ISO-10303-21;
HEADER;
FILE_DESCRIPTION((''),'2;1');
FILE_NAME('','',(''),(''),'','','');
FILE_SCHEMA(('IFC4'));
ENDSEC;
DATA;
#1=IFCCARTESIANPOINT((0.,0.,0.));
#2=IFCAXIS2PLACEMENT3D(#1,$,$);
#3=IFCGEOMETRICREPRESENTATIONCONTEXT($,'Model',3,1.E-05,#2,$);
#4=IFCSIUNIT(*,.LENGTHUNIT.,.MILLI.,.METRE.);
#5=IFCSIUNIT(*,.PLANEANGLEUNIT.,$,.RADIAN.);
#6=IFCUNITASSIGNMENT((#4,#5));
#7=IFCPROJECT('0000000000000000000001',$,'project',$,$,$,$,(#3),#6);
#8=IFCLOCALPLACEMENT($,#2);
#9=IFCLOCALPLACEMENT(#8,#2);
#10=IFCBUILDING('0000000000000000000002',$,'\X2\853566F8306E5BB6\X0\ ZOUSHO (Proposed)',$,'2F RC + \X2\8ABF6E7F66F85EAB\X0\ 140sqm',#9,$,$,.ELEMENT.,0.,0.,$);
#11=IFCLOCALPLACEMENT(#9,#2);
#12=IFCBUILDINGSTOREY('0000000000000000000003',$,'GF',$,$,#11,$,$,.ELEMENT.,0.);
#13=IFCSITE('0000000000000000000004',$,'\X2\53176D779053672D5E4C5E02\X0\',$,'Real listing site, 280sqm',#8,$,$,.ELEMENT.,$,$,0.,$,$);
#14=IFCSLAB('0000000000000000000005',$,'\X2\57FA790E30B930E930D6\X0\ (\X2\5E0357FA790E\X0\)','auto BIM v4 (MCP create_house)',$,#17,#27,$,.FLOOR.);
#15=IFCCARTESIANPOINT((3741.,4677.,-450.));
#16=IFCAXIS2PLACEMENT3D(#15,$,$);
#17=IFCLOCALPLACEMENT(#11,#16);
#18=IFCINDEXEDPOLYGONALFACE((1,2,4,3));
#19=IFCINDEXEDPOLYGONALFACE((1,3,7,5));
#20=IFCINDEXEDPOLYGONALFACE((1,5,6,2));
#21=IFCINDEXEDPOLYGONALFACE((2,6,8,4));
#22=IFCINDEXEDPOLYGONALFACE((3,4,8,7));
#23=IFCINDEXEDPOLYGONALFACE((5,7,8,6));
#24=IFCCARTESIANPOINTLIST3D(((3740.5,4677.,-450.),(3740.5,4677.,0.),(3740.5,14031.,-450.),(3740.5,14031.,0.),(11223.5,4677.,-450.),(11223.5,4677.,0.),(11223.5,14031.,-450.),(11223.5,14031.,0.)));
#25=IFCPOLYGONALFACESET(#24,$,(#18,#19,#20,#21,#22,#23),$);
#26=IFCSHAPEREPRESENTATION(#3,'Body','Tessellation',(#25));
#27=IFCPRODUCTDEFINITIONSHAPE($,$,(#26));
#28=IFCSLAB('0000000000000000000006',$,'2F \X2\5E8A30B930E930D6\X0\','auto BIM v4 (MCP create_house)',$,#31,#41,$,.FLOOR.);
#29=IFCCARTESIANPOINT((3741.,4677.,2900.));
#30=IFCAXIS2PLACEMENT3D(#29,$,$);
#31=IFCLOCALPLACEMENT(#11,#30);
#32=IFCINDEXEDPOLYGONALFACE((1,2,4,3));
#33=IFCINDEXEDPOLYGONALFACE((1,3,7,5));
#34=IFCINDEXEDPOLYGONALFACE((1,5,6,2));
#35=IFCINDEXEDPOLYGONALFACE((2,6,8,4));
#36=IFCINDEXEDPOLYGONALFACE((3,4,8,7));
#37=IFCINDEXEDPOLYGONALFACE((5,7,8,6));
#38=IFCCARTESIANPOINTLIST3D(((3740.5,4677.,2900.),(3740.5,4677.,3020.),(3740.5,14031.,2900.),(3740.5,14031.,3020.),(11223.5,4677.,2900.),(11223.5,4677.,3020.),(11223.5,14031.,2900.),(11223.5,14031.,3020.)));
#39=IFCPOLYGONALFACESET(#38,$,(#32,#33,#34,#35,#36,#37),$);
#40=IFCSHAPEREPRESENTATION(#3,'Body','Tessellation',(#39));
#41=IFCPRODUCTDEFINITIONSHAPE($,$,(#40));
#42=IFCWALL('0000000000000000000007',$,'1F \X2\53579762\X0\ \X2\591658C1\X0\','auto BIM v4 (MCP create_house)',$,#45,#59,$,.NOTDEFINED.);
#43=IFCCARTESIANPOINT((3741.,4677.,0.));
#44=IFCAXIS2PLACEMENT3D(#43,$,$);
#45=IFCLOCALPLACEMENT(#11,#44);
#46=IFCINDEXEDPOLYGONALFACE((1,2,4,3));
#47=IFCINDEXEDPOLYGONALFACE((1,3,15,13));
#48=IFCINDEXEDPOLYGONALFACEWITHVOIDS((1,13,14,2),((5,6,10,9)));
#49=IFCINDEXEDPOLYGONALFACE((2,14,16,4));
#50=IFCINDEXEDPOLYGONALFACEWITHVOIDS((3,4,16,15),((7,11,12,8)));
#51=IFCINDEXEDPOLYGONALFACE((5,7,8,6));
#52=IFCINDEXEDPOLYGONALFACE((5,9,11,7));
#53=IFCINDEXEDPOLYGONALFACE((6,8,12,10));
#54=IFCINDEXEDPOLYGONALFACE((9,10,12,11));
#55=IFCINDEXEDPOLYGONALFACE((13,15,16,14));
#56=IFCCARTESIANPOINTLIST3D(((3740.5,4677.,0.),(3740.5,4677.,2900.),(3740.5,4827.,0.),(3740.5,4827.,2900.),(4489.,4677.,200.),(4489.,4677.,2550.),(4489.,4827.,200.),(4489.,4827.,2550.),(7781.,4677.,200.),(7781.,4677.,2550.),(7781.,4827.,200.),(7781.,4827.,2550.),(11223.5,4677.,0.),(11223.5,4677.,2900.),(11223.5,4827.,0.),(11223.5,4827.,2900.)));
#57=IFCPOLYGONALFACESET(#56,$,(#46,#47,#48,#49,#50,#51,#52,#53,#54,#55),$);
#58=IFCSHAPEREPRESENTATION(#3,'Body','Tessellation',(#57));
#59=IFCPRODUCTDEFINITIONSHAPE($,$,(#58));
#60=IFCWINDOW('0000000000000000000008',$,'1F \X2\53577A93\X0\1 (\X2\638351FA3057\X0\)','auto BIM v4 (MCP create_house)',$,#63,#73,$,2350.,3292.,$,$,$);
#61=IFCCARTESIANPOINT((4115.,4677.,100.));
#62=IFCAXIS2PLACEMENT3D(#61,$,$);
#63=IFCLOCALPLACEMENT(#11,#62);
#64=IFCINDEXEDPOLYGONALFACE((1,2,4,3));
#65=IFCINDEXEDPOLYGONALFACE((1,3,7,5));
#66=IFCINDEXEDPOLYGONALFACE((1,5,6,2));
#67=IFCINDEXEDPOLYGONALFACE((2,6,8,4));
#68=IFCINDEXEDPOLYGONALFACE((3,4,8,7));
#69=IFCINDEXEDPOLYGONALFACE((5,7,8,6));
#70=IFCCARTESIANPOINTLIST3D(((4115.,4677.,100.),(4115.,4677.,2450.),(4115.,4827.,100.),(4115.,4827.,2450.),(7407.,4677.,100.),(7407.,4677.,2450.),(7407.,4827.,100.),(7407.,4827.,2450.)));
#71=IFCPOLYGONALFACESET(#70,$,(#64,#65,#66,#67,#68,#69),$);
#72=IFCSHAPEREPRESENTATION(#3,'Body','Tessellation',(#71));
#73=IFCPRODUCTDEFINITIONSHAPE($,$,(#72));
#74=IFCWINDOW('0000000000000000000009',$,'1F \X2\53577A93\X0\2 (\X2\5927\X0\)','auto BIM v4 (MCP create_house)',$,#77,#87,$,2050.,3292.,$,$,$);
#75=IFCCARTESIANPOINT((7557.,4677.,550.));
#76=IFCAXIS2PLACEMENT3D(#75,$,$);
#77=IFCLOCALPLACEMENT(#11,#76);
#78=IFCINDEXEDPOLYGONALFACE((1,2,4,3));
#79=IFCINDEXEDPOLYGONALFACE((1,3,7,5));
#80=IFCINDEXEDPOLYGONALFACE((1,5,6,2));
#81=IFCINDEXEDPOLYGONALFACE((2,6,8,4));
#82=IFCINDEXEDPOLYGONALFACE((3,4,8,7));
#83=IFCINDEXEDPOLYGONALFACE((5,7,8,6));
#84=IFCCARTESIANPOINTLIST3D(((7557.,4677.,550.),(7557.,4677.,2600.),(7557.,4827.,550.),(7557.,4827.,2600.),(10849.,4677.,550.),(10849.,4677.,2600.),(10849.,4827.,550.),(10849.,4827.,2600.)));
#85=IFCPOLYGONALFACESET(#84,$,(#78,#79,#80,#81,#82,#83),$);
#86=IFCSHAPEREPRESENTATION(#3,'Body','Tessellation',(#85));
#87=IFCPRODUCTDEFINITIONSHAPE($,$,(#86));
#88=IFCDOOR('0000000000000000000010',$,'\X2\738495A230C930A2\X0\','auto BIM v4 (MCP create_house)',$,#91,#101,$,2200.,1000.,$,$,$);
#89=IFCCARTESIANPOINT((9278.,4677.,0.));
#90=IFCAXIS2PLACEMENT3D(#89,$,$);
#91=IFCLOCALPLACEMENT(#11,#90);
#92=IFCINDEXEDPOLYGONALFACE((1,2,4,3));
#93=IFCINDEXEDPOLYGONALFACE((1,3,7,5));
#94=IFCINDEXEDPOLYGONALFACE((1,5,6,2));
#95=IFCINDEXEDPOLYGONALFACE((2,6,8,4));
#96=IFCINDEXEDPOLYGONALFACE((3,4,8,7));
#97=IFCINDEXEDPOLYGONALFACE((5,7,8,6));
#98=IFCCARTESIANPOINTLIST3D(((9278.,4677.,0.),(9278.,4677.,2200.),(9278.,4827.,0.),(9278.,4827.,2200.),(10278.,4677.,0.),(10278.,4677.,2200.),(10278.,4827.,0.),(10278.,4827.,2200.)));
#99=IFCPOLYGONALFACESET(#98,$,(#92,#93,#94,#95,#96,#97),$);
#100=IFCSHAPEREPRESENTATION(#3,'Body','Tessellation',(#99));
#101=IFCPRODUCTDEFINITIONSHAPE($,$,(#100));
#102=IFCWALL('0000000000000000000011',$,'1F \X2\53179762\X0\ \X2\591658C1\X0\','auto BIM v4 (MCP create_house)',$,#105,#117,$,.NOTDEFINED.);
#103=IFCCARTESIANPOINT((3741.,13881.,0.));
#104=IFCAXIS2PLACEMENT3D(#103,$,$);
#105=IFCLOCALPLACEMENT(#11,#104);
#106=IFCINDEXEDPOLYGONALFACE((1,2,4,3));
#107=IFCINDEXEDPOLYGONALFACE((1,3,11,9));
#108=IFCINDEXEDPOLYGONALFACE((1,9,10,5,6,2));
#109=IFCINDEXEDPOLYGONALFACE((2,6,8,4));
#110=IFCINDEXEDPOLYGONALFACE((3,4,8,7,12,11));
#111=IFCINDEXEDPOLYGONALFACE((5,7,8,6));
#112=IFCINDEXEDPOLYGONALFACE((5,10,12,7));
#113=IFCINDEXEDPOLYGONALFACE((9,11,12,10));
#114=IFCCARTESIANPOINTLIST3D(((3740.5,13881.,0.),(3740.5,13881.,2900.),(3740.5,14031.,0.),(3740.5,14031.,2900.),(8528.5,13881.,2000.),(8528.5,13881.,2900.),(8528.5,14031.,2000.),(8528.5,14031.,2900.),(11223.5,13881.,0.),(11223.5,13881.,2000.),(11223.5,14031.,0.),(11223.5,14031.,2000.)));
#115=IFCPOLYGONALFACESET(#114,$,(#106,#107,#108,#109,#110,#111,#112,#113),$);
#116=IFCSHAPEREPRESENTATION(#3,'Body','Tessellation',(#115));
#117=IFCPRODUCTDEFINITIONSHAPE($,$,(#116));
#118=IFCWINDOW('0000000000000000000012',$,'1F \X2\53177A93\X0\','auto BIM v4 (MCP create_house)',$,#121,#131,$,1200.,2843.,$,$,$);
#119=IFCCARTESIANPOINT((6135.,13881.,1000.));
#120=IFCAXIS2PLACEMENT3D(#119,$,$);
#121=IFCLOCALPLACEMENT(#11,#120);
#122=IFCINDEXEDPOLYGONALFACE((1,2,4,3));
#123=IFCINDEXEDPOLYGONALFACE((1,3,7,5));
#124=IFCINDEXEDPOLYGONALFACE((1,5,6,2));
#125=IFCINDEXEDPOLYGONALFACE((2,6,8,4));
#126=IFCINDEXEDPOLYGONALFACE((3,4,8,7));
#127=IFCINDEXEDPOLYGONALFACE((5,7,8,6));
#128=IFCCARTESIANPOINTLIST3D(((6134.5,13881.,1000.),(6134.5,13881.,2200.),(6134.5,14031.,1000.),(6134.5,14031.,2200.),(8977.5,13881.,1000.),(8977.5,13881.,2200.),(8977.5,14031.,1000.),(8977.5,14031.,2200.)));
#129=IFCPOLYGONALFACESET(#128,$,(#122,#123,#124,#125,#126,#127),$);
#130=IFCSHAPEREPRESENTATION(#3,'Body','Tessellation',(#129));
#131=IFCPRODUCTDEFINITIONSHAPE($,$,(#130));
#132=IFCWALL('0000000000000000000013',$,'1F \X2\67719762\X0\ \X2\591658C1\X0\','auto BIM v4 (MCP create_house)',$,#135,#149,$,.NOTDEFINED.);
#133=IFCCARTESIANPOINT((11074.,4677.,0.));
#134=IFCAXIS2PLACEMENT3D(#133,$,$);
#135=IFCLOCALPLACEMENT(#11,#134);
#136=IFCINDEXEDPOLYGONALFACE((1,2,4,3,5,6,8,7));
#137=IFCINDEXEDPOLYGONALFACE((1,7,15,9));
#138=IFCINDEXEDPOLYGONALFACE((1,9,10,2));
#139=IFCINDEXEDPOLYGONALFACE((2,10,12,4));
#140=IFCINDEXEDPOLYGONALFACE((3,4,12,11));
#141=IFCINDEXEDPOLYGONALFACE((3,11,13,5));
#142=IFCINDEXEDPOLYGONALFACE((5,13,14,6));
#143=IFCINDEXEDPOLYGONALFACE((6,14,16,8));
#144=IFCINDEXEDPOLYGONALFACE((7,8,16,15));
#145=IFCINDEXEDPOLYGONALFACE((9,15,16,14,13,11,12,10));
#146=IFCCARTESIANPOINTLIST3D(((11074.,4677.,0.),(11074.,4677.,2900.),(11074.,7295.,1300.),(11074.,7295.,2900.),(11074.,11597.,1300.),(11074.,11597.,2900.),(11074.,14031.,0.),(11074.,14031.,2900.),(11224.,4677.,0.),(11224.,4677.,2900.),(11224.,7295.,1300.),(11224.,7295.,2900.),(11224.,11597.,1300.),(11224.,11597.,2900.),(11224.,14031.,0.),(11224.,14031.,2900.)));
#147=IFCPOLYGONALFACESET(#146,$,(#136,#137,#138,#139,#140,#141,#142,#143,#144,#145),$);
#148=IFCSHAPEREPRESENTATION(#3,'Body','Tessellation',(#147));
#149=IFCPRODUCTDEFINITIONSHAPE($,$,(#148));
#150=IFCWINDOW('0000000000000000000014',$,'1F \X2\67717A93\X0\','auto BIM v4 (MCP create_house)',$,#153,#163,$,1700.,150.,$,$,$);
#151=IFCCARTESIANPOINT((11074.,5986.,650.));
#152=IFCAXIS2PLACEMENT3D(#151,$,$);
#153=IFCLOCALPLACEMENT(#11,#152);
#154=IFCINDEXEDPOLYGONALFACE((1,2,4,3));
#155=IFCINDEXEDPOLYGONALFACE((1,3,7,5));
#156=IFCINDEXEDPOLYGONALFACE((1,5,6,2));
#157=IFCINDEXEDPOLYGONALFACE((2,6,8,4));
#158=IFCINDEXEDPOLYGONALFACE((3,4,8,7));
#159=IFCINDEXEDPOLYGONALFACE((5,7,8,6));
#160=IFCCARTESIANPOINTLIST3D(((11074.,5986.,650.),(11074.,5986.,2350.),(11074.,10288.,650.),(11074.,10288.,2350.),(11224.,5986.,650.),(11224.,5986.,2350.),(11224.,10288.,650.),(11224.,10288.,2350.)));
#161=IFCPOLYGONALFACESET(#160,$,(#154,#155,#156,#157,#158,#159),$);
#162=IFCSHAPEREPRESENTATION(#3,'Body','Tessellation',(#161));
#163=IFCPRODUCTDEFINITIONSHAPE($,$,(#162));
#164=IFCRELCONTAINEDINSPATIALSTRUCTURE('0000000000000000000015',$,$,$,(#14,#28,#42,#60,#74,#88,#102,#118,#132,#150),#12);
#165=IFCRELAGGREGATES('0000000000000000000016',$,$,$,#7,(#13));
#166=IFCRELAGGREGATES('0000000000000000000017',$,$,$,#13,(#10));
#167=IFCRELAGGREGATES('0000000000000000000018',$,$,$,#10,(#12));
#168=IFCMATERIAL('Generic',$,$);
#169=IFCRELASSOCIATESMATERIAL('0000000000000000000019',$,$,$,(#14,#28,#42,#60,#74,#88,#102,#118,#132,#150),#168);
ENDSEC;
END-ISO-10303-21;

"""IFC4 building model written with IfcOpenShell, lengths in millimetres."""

from ifc_helpers import new_model, si_unit, frame, frame_2d, origin, place, context, project, spatial, rectangle, extrude, material, element, fill, save


model = new_model("IFC4")

# Units and contexts
model_context = context("Model", 3, precision=1e-05, world=origin())
ifc_project = project(units=[si_unit("LENGTHUNIT", "METRE", prefix="MILLI"), si_unit("PLANEANGLEUNIT", "RADIAN")], contexts=[model_context])

# Site, building, storey
site_placement = place(None, origin())
site = spatial("IfcSite", under=ifc_project, at=site_placement, Name="北海道札幌市", ObjectType="Real listing site, 280sqm", CompositionType="ELEMENT", RefElevation=0.0)
building_placement = place(site_placement, origin())
building = spatial("IfcBuilding", under=site, at=building_placement, Name="蔵書の家 ZOUSHO (Proposed)", ObjectType="2F RC + 調湿書庫 140sqm", CompositionType="ELEMENT", ElevationOfRefHeight=0.0, ElevationOfTerrain=0.0)
storey_placement = place(building_placement, origin())
storey = spatial("IfcBuildingStorey", under=building, at=storey_placement, Name="GF", CompositionType="ELEMENT", Elevation=0.0)

# Slabs
ifc_material = material(Name="Generic")
slab_1_placement = place(storey_placement, frame((3741.0, 4677.0, -450.0)))
element("IfcSlab", 1, at=slab_1_placement, inside=storey, material=ifc_material, Name="基礎スラブ (布基礎)", Description="auto BIM v4 (MCP create_house)", PredefinedType="FLOOR", context=model_context, shape_type="SweptSolid", body=[
    extrude(rectangle(XDim=7483.0, YDim=9354.0, at=frame_2d((3741.0, 4677.0))), frame((3741.0, 4677.0, -450.0)), (0.0, 0.0, 1.0), 450.0),
])
slab_2_placement = place(storey_placement, frame((3741.0, 4677.0, 2900.0)))
element("IfcSlab", 2, at=slab_2_placement, inside=storey, material=ifc_material, Name="2F 床スラブ", Description="auto BIM v4 (MCP create_house)", PredefinedType="FLOOR", context=model_context, shape_type="SweptSolid", body=[
    extrude(rectangle(XDim=7483.0, YDim=9354.0, at=frame_2d((3741.0, 4677.0))), frame((3741.0, 4677.0, 2900.0)), (0.0, 0.0, 1.0), 120.0),
])

# Wall, openings, windows, door
wall_1_placement = place(storey_placement, frame((3741.0, 4677.0, 0.0)))
wall_1 = element("IfcWall", 3, at=wall_1_placement, inside=storey, material=ifc_material, Name="1F 南面 外壁", Description="auto BIM v4 (MCP create_house)", PredefinedType="NOTDEFINED", context=model_context, shape_type="SweptSolid", body=[
    extrude(rectangle(XDim=7483.0, YDim=150.0, at=frame_2d((3741.0, 75.0))), frame((3741.0, 4677.0, 0.0)), (0.0, 0.0, 1.0), 2900.0),
])
opening_1_placement = place(storey_placement, frame((4115.0, 4677.0, 100.0)))
opening_1 = element("IfcOpeningElement", 4, at=opening_1_placement, cuts=wall_1, PredefinedType="NOTDEFINED", context=model_context, shape_type="SweptSolid", body=[
    extrude(rectangle(XDim=3292.0, YDim=150.0, at=frame_2d((1646.0, 75.0))), frame((4115.0, 4677.0, 100.0)), (0.0, 0.0, 1.0), 2350.0),
])
opening_2_placement = place(storey_placement, frame((7557.0, 4677.0, 550.0)))
opening_2 = element("IfcOpeningElement", 5, at=opening_2_placement, cuts=wall_1, PredefinedType="NOTDEFINED", context=model_context, shape_type="SweptSolid", body=[
    extrude(rectangle(XDim=3292.0, YDim=150.0, at=frame_2d((1646.0, 75.0))), frame((7557.0, 4677.0, 550.0)), (0.0, 0.0, 1.0), 2050.0),
])
opening_3_placement = place(storey_placement, frame((9278.0, 4677.0, 0.0)))
opening_3 = element("IfcOpeningElement", 6, at=opening_3_placement, cuts=wall_1, PredefinedType="NOTDEFINED", context=model_context, shape_type="SweptSolid", body=[
    extrude(rectangle(XDim=1000.0, YDim=150.0, at=frame_2d((500.0, 75.0))), frame((9278.0, 4677.0, 0.0)), (0.0, 0.0, 1.0), 2200.0),
])
window_1_placement = place(storey_placement, frame((4115.0, 4677.0, 100.0)))
window_1 = element("IfcWindow", 7, at=window_1_placement, inside=storey, material=ifc_material, Name="1F 南窓1 (掃出し)", Description="auto BIM v4 (MCP create_house)", OverallHeight=2350.0, OverallWidth=3292.0, context=model_context, shape_type="SweptSolid", body=[
    extrude(rectangle(XDim=3292.0, YDim=150.0, at=frame_2d((1646.0, 75.0))), frame((4115.0, 4677.0, 100.0)), (0.0, 0.0, 1.0), 2350.0),
])
fill(opening_1, window_1)
window_2_placement = place(storey_placement, frame((7557.0, 4677.0, 550.0)))
window_2 = element("IfcWindow", 8, at=window_2_placement, inside=storey, material=ifc_material, Name="1F 南窓2 (大)", Description="auto BIM v4 (MCP create_house)", OverallHeight=2050.0, OverallWidth=3292.0, context=model_context, shape_type="SweptSolid", body=[
    extrude(rectangle(XDim=3292.0, YDim=150.0, at=frame_2d((1646.0, 75.0))), frame((7557.0, 4677.0, 550.0)), (0.0, 0.0, 1.0), 2050.0),
])
fill(opening_2, window_2)
door_1_placement = place(storey_placement, frame((9278.0, 4677.0, 0.0)))
door_1 = element("IfcDoor", 9, at=door_1_placement, inside=storey, material=ifc_material, Name="玄関ドア", Description="auto BIM v4 (MCP create_house)", OverallHeight=2200.0, OverallWidth=1000.0, context=model_context, shape_type="SweptSolid", body=[
    extrude(rectangle(XDim=1000.0, YDim=150.0, at=frame_2d((500.0, 75.0))), frame((9278.0, 4677.0, 0.0)), (0.0, 0.0, 1.0), 2200.0),
])
fill(opening_3, door_1)

# Walls, openings, windows
wall_2_placement = place(storey_placement, frame((3741.0, 13881.0, 0.0)))
wall_2 = element("IfcWall", 10, at=wall_2_placement, inside=storey, material=ifc_material, Name="1F 北面 外壁", Description="auto BIM v4 (MCP create_house)", PredefinedType="NOTDEFINED", context=model_context, shape_type="SweptSolid", body=[
    extrude(rectangle(XDim=7483.0, YDim=150.0, at=frame_2d((3741.0, 75.0))), frame((3741.0, 13881.0, 0.0)), (0.0, 0.0, 1.0), 2900.0),
])
opening_4_placement = place(storey_placement, frame((6135.0, 13881.0, 1000.0)))
opening_4 = element("IfcOpeningElement", 11, at=opening_4_placement, cuts=wall_2, PredefinedType="NOTDEFINED", context=model_context, shape_type="SweptSolid", body=[
    extrude(rectangle(XDim=2843.0, YDim=150.0, at=frame_2d((1421.0, 75.0))), frame((6135.0, 13881.0, 1000.0)), (0.0, 0.0, 1.0), 1200.0),
])
window_3_placement = place(storey_placement, frame((6135.0, 13881.0, 1000.0)))
window_3 = element("IfcWindow", 12, at=window_3_placement, inside=storey, material=ifc_material, Name="1F 北窓", Description="auto BIM v4 (MCP create_house)", OverallHeight=1200.0, OverallWidth=2843.0, context=model_context, shape_type="SweptSolid", body=[
    extrude(rectangle(XDim=2843.0, YDim=150.0, at=frame_2d((1421.0, 75.0))), frame((6135.0, 13881.0, 1000.0)), (0.0, 0.0, 1.0), 1200.0),
])
fill(opening_4, window_3)
wall_3_placement = place(storey_placement, frame((11074.0, 4677.0, 0.0)))
wall_3 = element("IfcWall", 13, at=wall_3_placement, inside=storey, material=ifc_material, Name="1F 東面 外壁", Description="auto BIM v4 (MCP create_house)", PredefinedType="NOTDEFINED", context=model_context, shape_type="SweptSolid", body=[
    extrude(rectangle(XDim=150.0, YDim=9354.0, at=frame_2d((75.0, 4677.0))), frame((11074.0, 4677.0, 0.0)), (0.0, 0.0, 1.0), 2900.0),
])
opening_5_placement = place(storey_placement, frame((11074.0, 5986.0, 650.0)))
opening_5 = element("IfcOpeningElement", 14, at=opening_5_placement, cuts=wall_3, PredefinedType="NOTDEFINED", context=model_context, shape_type="SweptSolid", body=[
    extrude(rectangle(XDim=150.0, YDim=4302.0, at=frame_2d((75.0, 2151.0))), frame((11074.0, 5986.0, 650.0)), (0.0, 0.0, 1.0), 1700.0),
])
window_4_placement = place(storey_placement, frame((11074.0, 5986.0, 650.0)))
window_4 = element("IfcWindow", 15, at=window_4_placement, inside=storey, material=ifc_material, Name="1F 東窓", Description="auto BIM v4 (MCP create_house)", OverallHeight=1700.0, OverallWidth=150.0, context=model_context, shape_type="SweptSolid", body=[
    extrude(rectangle(XDim=150.0, YDim=4302.0, at=frame_2d((75.0, 2151.0))), frame((11074.0, 5986.0, 650.0)), (0.0, 0.0, 1.0), 1700.0),
])
fill(opening_5, window_4)

save(model, "model.ifc")
